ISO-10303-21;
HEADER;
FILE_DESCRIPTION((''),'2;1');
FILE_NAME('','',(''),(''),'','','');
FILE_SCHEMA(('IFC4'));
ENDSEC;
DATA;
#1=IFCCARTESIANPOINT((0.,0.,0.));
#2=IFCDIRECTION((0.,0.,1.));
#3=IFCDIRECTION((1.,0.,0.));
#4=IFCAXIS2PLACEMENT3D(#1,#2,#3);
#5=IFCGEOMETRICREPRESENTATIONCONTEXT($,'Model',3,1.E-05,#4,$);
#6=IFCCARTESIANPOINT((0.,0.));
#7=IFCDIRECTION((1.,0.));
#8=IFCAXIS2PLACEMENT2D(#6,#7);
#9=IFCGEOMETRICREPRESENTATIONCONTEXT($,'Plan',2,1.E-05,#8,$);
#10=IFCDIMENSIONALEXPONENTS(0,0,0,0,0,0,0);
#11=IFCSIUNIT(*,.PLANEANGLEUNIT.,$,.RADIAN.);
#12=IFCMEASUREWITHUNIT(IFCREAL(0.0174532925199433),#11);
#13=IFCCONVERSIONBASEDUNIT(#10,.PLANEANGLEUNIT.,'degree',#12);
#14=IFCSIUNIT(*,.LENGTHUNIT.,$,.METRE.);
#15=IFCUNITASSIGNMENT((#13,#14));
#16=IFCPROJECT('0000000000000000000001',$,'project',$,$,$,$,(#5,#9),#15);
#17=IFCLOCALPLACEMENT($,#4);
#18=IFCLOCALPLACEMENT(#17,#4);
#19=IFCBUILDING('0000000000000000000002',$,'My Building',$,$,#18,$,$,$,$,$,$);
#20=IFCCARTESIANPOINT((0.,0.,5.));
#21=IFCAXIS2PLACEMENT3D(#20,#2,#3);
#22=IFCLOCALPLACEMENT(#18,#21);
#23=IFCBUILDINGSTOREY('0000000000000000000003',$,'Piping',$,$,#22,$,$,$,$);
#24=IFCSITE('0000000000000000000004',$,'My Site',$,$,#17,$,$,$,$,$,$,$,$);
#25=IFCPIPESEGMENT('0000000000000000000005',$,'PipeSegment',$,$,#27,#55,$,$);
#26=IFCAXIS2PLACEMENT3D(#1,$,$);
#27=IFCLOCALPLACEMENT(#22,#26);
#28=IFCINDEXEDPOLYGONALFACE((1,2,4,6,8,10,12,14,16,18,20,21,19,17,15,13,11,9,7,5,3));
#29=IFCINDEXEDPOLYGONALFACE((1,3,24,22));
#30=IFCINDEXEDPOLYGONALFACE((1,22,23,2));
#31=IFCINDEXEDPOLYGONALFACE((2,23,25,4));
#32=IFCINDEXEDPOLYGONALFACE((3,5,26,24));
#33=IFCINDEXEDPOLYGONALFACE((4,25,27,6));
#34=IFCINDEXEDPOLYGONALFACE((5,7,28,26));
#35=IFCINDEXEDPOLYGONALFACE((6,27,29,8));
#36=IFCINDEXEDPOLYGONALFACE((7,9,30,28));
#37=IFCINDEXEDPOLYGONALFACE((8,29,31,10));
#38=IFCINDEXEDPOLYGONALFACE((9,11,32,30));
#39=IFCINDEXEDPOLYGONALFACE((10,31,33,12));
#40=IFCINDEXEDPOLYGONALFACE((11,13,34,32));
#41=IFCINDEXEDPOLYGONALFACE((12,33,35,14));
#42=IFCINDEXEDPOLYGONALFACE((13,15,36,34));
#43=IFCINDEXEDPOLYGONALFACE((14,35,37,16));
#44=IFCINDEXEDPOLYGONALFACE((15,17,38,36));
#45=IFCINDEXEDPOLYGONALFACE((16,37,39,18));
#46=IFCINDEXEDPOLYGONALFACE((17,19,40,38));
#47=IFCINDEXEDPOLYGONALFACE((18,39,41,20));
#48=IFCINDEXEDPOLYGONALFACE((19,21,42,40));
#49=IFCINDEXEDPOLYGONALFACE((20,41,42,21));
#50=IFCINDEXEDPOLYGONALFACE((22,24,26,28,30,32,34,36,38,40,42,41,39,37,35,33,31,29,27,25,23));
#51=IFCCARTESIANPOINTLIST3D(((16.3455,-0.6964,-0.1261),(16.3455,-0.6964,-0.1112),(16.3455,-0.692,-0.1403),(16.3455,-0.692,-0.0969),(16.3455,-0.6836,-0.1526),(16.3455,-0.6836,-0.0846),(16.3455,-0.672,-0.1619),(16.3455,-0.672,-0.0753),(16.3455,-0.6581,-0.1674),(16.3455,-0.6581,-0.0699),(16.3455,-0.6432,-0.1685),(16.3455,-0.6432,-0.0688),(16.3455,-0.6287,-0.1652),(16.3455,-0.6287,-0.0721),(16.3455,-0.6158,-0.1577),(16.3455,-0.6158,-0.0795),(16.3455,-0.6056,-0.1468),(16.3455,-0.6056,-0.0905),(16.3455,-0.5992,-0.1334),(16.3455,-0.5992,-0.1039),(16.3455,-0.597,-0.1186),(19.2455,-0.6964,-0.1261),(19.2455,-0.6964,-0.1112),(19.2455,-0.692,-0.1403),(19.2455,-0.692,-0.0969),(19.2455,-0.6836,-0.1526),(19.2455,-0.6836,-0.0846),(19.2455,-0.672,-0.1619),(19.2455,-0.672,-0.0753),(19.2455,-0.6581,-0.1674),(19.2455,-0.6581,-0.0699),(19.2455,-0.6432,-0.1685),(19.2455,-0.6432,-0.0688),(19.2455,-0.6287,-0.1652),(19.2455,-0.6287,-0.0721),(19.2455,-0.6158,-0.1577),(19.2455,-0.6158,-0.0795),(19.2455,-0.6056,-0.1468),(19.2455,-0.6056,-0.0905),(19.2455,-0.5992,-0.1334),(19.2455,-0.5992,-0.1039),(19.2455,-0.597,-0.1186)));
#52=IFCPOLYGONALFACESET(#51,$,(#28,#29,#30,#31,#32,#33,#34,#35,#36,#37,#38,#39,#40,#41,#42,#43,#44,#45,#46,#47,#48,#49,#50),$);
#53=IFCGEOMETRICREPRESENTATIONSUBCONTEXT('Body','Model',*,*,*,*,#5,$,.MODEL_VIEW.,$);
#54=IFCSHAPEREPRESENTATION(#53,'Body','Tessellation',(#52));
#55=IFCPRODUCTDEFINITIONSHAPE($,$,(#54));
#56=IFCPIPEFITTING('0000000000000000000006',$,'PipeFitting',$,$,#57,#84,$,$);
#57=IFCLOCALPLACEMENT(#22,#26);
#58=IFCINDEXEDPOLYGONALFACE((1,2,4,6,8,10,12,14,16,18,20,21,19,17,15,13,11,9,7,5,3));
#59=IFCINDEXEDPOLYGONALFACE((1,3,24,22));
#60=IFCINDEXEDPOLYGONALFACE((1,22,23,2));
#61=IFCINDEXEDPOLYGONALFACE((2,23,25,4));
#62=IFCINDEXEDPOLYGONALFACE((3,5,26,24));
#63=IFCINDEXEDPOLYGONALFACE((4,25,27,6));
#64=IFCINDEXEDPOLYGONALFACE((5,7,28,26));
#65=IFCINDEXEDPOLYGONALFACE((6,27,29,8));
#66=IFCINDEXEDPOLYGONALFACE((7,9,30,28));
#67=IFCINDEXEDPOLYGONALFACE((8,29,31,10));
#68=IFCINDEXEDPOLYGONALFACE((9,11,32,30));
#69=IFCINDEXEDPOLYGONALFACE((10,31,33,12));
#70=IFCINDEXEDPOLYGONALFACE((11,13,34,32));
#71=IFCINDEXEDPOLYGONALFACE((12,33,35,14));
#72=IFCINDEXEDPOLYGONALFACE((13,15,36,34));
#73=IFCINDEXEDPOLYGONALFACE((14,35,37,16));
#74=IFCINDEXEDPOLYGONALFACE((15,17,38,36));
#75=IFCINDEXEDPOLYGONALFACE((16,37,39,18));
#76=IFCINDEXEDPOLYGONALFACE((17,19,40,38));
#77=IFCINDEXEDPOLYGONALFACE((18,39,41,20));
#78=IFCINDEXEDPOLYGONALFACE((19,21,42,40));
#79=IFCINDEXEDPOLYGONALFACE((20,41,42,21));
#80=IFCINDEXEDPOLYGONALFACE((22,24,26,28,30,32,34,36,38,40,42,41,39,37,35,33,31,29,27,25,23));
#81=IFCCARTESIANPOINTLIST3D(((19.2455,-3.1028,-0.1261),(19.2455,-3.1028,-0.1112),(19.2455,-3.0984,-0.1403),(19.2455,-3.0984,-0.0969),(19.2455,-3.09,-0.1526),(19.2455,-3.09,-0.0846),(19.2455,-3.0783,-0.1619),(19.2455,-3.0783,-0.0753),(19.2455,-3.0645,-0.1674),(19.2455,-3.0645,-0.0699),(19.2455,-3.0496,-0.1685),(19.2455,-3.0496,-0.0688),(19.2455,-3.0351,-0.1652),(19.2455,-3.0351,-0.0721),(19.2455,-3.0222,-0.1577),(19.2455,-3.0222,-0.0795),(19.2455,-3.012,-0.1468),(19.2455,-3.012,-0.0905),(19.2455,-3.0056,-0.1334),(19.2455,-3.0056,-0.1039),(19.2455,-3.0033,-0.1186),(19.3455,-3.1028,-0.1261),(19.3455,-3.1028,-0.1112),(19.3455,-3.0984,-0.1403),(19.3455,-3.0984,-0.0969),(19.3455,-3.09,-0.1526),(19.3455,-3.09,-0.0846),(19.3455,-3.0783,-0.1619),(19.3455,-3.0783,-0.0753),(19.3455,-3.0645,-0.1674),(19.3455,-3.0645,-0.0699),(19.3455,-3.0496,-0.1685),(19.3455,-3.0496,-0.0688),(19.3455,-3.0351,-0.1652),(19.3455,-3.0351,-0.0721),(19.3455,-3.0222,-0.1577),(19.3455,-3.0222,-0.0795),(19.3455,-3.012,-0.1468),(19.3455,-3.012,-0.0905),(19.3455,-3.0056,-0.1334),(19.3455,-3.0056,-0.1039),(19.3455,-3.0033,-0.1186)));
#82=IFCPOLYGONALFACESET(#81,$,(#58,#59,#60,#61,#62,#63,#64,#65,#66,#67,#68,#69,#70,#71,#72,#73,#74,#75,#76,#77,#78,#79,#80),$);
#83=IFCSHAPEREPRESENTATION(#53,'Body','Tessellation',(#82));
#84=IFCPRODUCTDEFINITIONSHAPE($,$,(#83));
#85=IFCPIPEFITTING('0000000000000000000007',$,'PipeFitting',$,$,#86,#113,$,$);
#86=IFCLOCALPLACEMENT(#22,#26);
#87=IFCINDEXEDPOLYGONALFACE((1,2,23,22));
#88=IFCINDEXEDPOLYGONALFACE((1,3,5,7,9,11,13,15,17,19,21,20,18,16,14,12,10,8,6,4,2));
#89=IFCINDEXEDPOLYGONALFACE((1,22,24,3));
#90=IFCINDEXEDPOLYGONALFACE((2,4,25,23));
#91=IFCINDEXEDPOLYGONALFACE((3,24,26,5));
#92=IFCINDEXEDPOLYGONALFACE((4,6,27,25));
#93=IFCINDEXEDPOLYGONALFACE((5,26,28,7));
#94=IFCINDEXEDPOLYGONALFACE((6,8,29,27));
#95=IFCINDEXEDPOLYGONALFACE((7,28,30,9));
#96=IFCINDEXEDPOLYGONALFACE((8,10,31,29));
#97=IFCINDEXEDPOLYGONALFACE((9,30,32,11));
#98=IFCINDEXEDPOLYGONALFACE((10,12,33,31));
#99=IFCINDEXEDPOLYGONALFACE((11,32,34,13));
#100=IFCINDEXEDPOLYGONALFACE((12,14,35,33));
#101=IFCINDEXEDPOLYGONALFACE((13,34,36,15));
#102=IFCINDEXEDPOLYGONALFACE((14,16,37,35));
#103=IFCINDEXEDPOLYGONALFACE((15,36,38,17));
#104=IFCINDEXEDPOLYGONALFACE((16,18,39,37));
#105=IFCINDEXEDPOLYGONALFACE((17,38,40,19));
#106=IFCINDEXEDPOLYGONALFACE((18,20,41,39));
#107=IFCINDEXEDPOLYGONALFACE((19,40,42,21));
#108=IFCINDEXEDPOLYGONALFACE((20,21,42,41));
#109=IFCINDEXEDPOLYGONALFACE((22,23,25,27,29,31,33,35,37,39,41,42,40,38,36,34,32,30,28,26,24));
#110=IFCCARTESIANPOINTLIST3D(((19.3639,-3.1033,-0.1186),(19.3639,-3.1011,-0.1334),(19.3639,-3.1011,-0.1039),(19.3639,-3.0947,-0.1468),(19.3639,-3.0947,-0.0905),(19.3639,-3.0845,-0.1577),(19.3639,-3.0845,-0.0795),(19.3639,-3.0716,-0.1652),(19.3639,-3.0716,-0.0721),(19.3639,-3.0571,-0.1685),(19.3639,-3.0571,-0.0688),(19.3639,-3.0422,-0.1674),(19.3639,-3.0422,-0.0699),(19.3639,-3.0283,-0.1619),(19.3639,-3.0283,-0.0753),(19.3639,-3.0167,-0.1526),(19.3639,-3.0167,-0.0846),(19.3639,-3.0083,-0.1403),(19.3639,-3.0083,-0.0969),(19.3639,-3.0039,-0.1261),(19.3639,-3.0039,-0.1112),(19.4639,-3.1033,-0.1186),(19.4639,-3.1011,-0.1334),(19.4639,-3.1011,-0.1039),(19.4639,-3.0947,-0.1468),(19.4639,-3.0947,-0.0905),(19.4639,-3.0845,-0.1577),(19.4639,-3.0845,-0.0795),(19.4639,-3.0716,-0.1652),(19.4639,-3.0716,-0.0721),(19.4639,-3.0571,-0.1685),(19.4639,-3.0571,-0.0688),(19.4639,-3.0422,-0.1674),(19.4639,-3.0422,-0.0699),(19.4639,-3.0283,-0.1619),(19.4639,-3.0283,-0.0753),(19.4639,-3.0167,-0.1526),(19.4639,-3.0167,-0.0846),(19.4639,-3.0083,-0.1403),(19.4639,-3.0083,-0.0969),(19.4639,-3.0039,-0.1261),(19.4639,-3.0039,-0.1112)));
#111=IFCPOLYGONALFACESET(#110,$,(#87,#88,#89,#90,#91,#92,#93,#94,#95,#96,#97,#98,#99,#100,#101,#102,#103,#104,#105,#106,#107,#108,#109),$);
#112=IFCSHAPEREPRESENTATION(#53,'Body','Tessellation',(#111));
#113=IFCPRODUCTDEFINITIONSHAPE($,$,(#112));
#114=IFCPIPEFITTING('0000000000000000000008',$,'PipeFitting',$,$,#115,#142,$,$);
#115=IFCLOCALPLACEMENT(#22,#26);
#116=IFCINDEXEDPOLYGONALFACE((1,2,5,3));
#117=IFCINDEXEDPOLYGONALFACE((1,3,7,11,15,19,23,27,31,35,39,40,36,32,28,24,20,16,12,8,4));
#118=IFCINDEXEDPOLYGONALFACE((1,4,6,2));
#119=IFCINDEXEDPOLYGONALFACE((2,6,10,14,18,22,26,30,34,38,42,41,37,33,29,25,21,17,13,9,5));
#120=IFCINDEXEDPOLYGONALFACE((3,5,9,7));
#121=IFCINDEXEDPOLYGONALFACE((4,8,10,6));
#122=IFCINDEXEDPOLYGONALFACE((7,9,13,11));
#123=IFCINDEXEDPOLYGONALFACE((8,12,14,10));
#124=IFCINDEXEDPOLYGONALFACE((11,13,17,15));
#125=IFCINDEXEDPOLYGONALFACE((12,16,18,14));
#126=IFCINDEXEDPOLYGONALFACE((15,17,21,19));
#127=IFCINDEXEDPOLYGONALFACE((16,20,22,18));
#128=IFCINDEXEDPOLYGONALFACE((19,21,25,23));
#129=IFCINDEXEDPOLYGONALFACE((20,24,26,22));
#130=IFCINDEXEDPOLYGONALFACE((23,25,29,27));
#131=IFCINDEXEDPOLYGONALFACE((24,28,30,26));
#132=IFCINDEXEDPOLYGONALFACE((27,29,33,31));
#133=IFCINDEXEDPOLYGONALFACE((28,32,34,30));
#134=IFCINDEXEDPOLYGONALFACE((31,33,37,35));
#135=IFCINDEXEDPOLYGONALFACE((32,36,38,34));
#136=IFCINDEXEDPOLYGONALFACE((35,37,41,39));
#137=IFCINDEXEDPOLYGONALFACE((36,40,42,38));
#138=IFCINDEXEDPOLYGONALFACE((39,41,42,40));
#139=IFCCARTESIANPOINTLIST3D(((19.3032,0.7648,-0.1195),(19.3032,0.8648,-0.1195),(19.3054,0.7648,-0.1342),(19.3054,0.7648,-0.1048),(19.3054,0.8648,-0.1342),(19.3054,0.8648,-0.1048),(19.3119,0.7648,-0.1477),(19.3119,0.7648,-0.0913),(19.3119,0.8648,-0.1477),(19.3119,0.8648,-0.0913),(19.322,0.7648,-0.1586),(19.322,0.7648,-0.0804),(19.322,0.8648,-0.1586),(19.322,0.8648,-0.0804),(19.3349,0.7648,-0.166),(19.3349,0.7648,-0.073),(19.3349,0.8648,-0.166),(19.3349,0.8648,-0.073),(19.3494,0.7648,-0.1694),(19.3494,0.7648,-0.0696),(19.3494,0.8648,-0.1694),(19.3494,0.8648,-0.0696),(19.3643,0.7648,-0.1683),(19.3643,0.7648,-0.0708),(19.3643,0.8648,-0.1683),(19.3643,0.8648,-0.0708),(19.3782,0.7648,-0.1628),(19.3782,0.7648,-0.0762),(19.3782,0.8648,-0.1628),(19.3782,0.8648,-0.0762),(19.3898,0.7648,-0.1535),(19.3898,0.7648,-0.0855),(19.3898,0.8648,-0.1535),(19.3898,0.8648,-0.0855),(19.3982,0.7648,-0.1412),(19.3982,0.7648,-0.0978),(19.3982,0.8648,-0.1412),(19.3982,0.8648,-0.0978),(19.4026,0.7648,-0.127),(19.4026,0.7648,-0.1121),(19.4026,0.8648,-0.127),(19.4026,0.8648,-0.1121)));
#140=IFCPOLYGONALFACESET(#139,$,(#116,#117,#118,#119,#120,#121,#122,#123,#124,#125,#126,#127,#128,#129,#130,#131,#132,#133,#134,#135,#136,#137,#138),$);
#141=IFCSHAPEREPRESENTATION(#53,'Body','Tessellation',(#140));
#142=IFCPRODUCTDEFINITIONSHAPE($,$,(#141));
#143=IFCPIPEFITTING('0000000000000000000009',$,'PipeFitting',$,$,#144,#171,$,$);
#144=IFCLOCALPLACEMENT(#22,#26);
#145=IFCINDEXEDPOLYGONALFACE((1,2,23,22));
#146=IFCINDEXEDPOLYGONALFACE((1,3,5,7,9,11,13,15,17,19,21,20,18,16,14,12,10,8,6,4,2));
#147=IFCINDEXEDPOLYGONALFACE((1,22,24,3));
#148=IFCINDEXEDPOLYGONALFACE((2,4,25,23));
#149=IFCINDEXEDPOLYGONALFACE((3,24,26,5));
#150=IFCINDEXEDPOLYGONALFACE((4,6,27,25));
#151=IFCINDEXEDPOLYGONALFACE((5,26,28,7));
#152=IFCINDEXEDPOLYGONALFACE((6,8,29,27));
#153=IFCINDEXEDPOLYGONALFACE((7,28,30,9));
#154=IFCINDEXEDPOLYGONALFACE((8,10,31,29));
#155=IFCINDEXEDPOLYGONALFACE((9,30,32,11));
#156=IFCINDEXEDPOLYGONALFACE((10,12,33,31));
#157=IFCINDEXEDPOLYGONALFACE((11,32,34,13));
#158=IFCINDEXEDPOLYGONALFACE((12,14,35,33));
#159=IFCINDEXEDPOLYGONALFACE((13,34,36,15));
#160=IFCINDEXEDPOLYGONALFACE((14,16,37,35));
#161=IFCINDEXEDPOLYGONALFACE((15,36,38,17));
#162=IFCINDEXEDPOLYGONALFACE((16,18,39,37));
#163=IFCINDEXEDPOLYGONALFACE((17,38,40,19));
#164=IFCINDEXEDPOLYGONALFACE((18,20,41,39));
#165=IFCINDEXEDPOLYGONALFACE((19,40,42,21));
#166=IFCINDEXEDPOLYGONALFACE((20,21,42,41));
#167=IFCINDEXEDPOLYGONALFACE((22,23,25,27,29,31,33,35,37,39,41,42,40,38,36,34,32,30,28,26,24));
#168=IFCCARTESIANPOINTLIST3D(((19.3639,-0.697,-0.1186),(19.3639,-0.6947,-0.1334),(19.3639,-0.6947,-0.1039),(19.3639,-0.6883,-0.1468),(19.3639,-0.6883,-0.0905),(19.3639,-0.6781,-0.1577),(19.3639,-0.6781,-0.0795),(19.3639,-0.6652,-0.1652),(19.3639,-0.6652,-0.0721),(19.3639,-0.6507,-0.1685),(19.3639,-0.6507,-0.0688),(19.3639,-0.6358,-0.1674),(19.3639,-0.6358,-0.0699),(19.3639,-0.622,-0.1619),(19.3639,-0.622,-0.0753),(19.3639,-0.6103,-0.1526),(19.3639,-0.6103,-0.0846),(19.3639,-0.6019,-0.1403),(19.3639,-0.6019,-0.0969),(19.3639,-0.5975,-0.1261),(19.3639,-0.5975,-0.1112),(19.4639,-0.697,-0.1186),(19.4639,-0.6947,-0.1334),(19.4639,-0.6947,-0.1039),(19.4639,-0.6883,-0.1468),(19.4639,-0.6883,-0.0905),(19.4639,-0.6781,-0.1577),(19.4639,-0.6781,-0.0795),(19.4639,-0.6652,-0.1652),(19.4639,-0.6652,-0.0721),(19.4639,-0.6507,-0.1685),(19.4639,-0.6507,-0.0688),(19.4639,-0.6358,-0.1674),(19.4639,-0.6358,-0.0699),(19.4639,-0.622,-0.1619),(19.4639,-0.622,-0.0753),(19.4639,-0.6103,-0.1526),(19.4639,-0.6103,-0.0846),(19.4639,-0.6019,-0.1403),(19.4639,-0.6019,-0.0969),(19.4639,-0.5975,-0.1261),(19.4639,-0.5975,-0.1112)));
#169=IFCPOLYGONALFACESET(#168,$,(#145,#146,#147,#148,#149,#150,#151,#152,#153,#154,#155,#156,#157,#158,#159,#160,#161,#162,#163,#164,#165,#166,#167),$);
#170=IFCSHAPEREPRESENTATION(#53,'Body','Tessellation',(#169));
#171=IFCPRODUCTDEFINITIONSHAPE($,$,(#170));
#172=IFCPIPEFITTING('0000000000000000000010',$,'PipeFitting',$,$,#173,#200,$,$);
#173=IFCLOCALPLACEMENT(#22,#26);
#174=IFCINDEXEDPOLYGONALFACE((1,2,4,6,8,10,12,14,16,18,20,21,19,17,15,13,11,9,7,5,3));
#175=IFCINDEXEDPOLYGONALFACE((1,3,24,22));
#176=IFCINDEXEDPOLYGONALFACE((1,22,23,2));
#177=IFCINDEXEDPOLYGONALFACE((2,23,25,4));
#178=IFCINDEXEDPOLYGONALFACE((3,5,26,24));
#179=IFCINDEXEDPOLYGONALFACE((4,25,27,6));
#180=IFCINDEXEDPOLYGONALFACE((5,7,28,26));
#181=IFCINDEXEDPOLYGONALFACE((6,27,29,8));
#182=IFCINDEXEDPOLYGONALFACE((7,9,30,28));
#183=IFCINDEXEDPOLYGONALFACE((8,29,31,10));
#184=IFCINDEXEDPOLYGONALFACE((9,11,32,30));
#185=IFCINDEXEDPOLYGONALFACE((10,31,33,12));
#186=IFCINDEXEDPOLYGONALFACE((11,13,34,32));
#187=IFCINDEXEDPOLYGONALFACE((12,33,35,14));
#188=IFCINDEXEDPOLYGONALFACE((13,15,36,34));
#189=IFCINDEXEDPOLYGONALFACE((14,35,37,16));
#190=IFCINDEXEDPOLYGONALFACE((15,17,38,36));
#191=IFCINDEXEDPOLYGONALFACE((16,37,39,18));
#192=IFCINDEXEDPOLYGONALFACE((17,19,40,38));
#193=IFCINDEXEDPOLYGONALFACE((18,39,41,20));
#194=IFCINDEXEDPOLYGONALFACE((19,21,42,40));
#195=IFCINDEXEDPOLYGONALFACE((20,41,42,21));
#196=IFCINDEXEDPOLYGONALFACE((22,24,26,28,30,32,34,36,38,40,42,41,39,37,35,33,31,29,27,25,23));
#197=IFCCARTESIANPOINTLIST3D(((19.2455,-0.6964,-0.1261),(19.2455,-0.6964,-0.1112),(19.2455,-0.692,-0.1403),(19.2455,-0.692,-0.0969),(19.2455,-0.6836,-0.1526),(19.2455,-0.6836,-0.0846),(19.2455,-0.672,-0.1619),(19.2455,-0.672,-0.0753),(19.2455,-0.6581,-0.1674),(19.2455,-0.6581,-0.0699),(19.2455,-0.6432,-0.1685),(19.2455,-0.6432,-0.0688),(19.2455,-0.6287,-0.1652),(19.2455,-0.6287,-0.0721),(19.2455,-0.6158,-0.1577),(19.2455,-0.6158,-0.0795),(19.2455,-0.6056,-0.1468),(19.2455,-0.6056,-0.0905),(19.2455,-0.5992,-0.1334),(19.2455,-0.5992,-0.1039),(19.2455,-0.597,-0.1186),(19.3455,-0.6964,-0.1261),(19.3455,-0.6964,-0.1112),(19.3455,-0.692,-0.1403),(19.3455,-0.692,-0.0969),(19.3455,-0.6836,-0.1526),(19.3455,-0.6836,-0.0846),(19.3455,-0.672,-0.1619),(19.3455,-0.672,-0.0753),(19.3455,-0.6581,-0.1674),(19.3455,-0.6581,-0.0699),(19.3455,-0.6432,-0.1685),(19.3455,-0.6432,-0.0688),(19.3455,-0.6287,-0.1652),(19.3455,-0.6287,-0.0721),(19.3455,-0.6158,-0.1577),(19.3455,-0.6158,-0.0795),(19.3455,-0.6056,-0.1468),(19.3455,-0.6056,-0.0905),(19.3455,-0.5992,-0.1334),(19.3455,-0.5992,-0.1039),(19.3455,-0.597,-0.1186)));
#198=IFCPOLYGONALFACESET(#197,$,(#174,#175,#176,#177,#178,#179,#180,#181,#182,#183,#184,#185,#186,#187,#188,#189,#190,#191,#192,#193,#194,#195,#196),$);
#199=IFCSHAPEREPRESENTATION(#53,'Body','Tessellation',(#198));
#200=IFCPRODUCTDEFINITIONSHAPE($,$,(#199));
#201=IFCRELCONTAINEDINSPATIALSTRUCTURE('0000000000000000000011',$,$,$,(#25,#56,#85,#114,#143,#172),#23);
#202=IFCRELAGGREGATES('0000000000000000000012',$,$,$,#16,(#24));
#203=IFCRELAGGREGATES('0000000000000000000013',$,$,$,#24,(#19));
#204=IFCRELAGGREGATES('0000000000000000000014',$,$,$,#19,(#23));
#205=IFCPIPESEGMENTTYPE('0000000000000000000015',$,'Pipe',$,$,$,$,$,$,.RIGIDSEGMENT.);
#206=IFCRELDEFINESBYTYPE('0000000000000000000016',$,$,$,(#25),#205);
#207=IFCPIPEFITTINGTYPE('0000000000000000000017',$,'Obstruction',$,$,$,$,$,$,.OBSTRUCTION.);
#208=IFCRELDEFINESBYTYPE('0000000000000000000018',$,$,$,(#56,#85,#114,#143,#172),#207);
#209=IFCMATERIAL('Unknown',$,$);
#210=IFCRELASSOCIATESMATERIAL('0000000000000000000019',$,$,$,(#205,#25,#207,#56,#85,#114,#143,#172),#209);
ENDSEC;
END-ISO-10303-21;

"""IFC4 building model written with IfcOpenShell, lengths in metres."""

from ifc_helpers import new_model, entity, si_unit, converted_unit, frame, origin_with_axes, origin_2d_with_axis, place, context, subcontext, project, spatial, circle, extrude, material, material_profile, profile_set, profile_usage, type_object, element, save


model = new_model("IFC4")

# Units and contexts
model_context = context("Model", 3, precision=1e-05, world=origin_with_axes())
plan_context = context("Plan", 2, precision=1e-05, world=origin_2d_with_axis())
body_context = subcontext(model_context, "Body", "Model", "MODEL_VIEW")
ifc_project = project(units=[converted_unit("PLANEANGLEUNIT", "degree", entity("IfcReal", 0.0174532925199433), si_unit("PLANEANGLEUNIT", "RADIAN"), dimensions=[0, 0, 0, 0, 0, 0, 0]), si_unit("LENGTHUNIT", "METRE")], contexts=[model_context, plan_context])

# Site, building, storey
site_placement = place(None, origin_with_axes())
site = spatial("IfcSite", under=ifc_project, at=site_placement, Name="My Site")
building_placement = place(site_placement, origin_with_axes())
building = spatial("IfcBuilding", under=site, at=building_placement, Name="My Building")
storey_placement = place(building_placement, frame((0.0, 0.0, 5.0), z_axis=(0.0, 0.0, 1.0), x_axis=(1.0, 0.0, 0.0)))
storey = spatial("IfcBuildingStorey", under=building, at=storey_placement, Name="Piping")

# Pipe segment
ifc_material = material(Name="Unknown")
ifc_material_profile_1 = material_profile(ifc_material, circle(Radius=0.05))
ifc_profile_set_1 = profile_set([ifc_material_profile_1])
pipe_segment_type = type_object("IfcPipeSegmentType", Name="Pipe", PredefinedType="RIGIDSEGMENT", material=ifc_profile_set_1)
ifc_profile_usage_1 = profile_usage(ifc_profile_set_1, cardinal=5)
pipe_segment_1_placement = place(storey_placement, frame((16.3455, -0.647, -0.1186), z_axis=(1.0, 0.0, 0.0), x_axis=(0.0, 1.0, 0.0)))
element("IfcPipeSegment", 1, at=pipe_segment_1_placement, inside=storey, type_object=pipe_segment_type, material=ifc_profile_usage_1, Name="PipeSegment", context=body_context, shape_type="SweptSolid", body=[
    extrude(circle(Radius=0.05), origin_with_axes(), (0.0, 0.0, 1.0), 2.9),
])

# Pipe fittings
ifc_material_profile_2 = material_profile(ifc_material, circle(Radius=0.05))
ifc_profile_set_2 = profile_set([ifc_material_profile_2])
ifc_profile_usage_2 = profile_usage(ifc_profile_set_2, cardinal=5)
pipe_fitting_type_1 = type_object("IfcPipeFittingType", Name="Obstruction", PredefinedType="OBSTRUCTION", material=ifc_profile_set_2)
pipe_fitting_1_placement = place(storey_placement, frame((19.2455, -3.0533, -0.1186), z_axis=(1.0, 0.0, 0.0), x_axis=(0.0, 1.0, 0.0)))
element("IfcPipeFitting", 2, at=pipe_fitting_1_placement, inside=storey, type_object=pipe_fitting_type_1, material=ifc_profile_usage_2, Name="PipeFitting", context=body_context, shape_type="SweptSolid", body=[
    extrude(circle(Radius=0.05), origin_with_axes(), (0.0, 0.0, 1.0), 0.1),
])
ifc_profile_usage_3 = profile_usage(ifc_profile_set_2, cardinal=5)
pipe_fitting_2_placement = place(storey_placement, frame((19.4639, -3.0533, -0.1186), z_axis=(-1.0, 0.0, 0.0), x_axis=(0.0, -1.0, 0.0)))
element("IfcPipeFitting", 3, at=pipe_fitting_2_placement, inside=storey, type_object=pipe_fitting_type_1, material=ifc_profile_usage_3, Name="PipeFitting", context=body_context, shape_type="SweptSolid", body=[
    extrude(circle(Radius=0.05), origin_with_axes(), (0.0, 0.0, 1.0), 0.1),
])
ifc_profile_usage_4 = profile_usage(ifc_profile_set_2, cardinal=5)
pipe_fitting_3_placement = place(storey_placement, frame((19.3532, 0.7648, -0.1195), z_axis=(0.0, 1.0, 0.0), x_axis=(-1.0, 0.0, 0.0)))
element("IfcPipeFitting", 4, at=pipe_fitting_3_placement, inside=storey, type_object=pipe_fitting_type_1, material=ifc_profile_usage_4, Name="PipeFitting", context=body_context, shape_type="SweptSolid", body=[
    extrude(circle(Radius=0.05), origin_with_axes(), (0.0, 0.0, 1.0), 0.1),
])
ifc_profile_usage_5 = profile_usage(ifc_profile_set_2, cardinal=5)
pipe_fitting_4_placement = place(storey_placement, frame((19.4639, -0.647, -0.1186), z_axis=(-1.0, 0.0, 0.0), x_axis=(0.0, -1.0, 0.0)))
element("IfcPipeFitting", 5, at=pipe_fitting_4_placement, inside=storey, type_object=pipe_fitting_type_1, material=ifc_profile_usage_5, Name="PipeFitting", context=body_context, shape_type="SweptSolid", body=[
    extrude(circle(Radius=0.05), origin_with_axes(), (0.0, 0.0, 1.0), 0.1),
])
ifc_profile_usage_6 = profile_usage(ifc_profile_set_2, cardinal=5)
pipe_fitting_5_placement = place(storey_placement, frame((19.2455, -0.647, -0.1186), z_axis=(1.0, 0.0, 0.0), x_axis=(0.0, 1.0, 0.0)))
element("IfcPipeFitting", 6, at=pipe_fitting_5_placement, inside=storey, type_object=pipe_fitting_type_1, material=ifc_profile_usage_6, Name="PipeFitting", context=body_context, shape_type="SweptSolid", body=[
    extrude(circle(Radius=0.05), origin_with_axes(), (0.0, 0.0, 1.0), 0.1),
])

save(model, "model.ifc")
